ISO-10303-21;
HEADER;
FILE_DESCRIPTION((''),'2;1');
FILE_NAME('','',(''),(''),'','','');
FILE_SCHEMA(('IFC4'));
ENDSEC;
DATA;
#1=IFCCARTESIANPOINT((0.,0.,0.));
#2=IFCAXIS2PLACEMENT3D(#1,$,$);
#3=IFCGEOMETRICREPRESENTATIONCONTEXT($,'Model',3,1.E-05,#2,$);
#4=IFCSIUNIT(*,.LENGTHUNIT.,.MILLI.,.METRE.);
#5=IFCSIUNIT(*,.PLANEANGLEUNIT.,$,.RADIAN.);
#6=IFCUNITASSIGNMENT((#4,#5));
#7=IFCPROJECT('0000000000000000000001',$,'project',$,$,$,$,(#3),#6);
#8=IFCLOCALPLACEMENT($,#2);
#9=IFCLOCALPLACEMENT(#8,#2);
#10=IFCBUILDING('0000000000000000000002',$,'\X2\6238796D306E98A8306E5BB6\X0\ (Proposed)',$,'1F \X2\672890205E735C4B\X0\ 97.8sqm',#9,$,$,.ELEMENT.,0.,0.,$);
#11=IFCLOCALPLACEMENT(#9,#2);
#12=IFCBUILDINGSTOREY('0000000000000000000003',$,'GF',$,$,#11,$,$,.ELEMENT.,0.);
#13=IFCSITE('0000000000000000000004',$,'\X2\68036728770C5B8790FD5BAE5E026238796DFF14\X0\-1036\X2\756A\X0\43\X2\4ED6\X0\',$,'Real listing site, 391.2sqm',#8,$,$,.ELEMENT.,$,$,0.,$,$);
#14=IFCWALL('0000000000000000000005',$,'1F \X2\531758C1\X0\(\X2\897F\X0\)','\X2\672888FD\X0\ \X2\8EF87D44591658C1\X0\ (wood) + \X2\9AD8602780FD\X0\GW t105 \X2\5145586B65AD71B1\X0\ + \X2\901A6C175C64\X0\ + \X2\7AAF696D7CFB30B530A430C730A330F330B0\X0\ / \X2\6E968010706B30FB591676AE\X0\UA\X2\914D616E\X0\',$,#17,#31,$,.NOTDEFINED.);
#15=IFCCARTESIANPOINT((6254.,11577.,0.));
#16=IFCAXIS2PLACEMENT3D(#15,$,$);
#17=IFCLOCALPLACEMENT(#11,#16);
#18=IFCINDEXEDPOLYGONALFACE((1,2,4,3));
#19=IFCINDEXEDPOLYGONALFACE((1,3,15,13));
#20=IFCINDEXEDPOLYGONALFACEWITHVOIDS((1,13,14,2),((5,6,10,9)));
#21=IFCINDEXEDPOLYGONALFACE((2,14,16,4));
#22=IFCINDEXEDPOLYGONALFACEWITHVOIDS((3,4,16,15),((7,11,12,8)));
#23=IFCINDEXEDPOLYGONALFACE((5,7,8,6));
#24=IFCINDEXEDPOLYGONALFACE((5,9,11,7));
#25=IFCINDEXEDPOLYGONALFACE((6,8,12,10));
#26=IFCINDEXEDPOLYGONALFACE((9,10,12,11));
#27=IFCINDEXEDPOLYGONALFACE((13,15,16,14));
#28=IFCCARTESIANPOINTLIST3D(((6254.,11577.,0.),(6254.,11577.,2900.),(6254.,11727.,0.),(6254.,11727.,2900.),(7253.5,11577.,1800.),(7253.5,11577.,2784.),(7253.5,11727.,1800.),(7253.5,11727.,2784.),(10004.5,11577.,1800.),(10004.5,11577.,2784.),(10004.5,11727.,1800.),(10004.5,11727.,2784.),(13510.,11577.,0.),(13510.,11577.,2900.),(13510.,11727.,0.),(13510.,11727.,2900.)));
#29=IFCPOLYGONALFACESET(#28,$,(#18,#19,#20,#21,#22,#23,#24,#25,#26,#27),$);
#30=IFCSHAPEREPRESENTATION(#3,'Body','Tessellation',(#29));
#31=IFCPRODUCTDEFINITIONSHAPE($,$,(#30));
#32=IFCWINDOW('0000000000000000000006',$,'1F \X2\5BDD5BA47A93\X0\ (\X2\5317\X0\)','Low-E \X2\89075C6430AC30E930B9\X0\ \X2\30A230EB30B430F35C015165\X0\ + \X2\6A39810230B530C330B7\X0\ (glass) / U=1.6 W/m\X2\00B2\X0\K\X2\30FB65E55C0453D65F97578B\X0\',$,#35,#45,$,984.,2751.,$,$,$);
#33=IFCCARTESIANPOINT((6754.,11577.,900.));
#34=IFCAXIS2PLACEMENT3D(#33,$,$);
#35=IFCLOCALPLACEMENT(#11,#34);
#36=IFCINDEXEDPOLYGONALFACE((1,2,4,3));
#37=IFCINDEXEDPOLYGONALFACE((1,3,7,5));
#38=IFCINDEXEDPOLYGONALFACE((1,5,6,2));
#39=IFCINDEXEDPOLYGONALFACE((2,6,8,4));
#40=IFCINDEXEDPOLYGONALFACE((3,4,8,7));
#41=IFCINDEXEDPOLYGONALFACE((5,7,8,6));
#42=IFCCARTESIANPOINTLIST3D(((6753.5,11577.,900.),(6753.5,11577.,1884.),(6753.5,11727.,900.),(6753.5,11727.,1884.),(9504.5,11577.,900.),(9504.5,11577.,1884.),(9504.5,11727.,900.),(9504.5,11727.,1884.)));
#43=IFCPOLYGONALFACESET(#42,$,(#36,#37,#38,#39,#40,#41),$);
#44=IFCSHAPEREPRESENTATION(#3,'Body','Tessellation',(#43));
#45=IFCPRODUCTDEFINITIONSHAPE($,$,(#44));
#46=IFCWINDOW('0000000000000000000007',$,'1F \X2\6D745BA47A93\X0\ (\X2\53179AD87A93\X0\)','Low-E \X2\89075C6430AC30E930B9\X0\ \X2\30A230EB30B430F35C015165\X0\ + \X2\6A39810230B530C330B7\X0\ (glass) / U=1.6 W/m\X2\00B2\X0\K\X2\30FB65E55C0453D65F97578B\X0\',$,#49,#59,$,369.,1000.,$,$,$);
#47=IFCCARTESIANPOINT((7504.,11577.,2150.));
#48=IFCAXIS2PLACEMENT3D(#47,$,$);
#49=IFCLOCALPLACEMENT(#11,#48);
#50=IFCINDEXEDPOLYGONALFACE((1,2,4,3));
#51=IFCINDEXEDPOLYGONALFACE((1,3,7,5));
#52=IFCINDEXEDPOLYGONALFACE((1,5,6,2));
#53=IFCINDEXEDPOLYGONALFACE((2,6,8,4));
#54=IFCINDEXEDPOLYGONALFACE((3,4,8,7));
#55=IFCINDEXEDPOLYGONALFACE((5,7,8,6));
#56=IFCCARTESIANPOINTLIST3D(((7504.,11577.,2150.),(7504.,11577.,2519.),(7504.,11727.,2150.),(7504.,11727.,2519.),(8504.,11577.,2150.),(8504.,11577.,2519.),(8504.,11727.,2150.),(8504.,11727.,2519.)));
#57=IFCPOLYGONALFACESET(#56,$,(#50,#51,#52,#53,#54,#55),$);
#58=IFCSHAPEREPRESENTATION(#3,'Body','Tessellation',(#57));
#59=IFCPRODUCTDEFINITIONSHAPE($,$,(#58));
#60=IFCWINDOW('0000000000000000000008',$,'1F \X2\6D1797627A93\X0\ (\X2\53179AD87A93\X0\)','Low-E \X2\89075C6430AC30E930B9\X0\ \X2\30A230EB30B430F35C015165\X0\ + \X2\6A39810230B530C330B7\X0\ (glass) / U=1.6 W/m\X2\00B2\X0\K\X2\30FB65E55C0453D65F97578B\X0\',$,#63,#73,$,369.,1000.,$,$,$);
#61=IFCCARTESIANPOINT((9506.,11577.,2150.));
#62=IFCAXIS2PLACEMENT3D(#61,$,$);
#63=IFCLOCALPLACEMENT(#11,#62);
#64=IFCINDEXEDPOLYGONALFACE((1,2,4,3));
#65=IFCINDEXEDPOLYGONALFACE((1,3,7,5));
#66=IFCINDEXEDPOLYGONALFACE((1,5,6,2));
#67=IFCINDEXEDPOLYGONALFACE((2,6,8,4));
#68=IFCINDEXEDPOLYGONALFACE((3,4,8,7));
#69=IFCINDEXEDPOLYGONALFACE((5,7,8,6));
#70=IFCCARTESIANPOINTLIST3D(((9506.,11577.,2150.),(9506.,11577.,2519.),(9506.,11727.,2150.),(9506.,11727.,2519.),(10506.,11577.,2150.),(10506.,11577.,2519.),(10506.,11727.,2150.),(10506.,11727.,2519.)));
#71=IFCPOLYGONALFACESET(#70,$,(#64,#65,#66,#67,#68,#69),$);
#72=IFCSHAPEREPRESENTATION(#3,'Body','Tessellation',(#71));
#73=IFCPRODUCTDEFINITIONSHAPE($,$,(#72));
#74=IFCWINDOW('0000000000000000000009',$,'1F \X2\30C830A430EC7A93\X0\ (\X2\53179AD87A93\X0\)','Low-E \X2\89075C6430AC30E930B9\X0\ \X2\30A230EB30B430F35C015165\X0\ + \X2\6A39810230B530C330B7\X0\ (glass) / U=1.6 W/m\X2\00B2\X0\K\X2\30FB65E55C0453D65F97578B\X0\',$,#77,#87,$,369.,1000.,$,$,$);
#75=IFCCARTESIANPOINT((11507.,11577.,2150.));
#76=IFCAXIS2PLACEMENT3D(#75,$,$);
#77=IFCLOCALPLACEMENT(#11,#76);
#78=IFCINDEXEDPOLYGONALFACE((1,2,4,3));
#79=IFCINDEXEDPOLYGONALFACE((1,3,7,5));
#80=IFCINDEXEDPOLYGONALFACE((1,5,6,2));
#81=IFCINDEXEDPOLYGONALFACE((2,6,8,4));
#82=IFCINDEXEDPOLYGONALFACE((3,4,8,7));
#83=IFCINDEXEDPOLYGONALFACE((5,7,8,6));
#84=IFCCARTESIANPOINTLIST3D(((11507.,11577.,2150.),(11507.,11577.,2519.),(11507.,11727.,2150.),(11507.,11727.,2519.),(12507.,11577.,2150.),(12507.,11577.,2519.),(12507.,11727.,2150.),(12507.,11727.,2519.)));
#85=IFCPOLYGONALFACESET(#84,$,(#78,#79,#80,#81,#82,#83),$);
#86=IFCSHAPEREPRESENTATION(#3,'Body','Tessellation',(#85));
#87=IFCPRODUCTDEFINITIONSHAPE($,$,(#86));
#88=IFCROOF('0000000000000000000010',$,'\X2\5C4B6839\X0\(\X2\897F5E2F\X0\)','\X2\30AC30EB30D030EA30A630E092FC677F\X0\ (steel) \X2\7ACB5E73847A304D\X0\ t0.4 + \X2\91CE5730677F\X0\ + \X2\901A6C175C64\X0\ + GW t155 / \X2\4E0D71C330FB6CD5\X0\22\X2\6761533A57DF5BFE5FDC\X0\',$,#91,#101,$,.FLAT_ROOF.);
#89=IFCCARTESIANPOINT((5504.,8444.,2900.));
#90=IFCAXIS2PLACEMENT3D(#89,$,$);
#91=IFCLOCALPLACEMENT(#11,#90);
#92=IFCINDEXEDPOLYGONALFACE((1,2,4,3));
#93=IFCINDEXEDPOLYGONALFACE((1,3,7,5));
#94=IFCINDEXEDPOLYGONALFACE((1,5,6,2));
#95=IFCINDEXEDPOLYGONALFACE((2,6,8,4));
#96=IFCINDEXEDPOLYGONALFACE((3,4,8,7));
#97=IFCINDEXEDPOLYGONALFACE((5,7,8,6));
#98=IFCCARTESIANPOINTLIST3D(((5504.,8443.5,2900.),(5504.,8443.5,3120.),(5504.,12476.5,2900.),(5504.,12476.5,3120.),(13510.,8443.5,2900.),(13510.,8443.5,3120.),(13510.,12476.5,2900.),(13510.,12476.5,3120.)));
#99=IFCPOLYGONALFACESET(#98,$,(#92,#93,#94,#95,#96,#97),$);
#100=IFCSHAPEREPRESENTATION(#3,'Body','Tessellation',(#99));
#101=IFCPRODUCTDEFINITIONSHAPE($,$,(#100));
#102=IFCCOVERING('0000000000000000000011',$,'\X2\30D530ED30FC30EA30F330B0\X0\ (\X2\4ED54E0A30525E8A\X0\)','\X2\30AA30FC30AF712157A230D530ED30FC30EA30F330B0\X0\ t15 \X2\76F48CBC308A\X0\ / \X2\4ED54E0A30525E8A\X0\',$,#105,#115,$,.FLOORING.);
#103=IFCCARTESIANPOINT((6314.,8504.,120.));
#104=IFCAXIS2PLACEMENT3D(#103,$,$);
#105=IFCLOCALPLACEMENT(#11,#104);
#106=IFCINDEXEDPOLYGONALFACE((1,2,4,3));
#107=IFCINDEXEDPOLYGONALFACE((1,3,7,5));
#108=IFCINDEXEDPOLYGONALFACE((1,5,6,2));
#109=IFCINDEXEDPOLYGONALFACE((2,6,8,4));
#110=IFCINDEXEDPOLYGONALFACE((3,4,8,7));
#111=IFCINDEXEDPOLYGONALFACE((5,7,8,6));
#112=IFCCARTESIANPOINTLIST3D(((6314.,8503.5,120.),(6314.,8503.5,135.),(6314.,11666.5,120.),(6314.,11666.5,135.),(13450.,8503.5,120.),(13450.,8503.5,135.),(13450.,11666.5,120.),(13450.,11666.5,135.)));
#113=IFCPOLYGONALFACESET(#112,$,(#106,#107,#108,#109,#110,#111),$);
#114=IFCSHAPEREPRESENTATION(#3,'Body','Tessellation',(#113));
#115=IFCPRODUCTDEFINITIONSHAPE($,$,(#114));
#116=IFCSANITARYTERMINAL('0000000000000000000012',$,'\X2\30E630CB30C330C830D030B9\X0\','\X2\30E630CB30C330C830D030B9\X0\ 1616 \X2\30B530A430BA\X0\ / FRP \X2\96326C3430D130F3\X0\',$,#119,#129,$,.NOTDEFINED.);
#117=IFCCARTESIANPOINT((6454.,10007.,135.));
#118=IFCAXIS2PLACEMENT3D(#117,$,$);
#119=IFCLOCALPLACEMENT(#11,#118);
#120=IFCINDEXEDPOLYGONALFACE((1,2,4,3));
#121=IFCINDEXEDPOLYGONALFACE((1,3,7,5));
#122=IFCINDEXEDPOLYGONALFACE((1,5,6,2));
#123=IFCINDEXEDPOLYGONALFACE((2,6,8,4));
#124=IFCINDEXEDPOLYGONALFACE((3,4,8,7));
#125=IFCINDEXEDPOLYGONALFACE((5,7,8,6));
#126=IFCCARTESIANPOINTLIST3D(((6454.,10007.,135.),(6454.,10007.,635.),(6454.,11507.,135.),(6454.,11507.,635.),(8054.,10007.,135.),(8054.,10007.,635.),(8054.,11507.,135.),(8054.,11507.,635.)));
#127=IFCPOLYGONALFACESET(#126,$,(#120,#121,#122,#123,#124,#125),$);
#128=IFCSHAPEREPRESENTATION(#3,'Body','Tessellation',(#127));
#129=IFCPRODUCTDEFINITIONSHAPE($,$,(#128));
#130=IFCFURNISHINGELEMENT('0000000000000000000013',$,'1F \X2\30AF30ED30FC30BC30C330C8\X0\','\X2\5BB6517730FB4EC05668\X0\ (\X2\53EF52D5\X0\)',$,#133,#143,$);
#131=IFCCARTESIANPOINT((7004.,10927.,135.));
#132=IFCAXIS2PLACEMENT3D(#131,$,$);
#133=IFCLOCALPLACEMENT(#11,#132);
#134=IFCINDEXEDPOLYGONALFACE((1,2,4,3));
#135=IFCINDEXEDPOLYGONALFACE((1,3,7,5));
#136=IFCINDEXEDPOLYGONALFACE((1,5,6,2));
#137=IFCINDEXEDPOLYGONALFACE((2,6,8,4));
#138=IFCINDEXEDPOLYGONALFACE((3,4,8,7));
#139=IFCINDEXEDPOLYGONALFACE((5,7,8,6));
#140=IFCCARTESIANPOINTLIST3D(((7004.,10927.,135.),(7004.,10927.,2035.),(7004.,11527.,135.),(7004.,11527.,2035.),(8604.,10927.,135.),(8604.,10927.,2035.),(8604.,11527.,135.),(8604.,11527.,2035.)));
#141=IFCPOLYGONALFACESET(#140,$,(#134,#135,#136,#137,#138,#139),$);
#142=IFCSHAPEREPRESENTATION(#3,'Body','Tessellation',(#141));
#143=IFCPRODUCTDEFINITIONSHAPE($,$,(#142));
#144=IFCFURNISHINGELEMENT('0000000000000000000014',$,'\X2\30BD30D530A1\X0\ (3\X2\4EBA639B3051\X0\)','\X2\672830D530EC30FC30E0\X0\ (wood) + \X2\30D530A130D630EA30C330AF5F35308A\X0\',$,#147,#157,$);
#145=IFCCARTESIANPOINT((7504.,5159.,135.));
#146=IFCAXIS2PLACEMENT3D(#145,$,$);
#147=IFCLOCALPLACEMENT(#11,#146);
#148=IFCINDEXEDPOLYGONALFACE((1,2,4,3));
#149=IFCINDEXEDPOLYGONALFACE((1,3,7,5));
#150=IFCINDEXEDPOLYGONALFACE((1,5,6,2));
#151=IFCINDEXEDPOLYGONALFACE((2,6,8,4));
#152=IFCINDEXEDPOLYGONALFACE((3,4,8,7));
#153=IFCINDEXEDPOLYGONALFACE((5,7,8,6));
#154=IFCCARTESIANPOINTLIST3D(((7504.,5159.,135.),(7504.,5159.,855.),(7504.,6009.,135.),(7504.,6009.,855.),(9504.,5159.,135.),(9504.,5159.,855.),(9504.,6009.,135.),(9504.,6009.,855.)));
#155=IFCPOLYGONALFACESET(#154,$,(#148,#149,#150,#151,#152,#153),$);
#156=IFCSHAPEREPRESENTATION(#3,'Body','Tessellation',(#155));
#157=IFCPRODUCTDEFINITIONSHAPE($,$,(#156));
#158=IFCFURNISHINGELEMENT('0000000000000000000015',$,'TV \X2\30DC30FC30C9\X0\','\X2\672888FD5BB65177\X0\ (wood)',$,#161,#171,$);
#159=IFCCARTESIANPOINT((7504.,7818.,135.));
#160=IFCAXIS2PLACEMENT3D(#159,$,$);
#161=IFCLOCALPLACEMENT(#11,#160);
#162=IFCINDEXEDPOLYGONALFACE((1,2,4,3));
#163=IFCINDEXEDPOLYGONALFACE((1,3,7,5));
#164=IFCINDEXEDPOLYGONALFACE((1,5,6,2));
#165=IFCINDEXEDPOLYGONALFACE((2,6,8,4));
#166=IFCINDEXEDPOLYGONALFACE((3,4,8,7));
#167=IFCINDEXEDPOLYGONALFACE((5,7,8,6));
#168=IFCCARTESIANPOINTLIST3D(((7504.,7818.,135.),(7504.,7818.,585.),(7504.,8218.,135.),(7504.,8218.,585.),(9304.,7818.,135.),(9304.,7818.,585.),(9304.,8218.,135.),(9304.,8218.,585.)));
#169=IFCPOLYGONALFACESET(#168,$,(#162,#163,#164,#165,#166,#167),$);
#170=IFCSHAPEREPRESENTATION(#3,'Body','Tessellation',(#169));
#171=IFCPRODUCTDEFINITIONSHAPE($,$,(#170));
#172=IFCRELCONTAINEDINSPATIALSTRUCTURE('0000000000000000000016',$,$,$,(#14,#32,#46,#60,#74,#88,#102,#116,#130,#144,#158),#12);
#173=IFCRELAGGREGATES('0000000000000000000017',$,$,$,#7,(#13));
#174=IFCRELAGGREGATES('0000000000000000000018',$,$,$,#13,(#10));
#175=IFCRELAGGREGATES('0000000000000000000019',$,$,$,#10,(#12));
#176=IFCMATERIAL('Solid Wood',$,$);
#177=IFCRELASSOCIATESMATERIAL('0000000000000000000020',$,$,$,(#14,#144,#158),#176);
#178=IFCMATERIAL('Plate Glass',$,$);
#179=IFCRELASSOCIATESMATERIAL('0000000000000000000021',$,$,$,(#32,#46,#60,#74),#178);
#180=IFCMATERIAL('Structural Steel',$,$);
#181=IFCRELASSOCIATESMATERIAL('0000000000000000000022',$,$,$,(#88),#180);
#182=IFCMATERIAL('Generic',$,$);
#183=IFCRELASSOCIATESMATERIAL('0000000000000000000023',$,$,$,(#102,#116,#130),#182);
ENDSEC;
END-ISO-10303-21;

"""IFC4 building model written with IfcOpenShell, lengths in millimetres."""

from ifc_helpers import new_model, si_unit, frame, frame_2d, origin, place, context, project, spatial, rectangle, extrude, material, element, fill, save


model = new_model("IFC4")

# Units and contexts
model_context = context("Model", 3, precision=1e-05, world=origin())
ifc_project = project(units=[si_unit("LENGTHUNIT", "METRE", prefix="MILLI"), si_unit("PLANEANGLEUNIT", "RADIAN")], contexts=[model_context])

# Site, building, storey
site_placement = place(None, origin())
site = spatial("IfcSite", under=ifc_project, at=site_placement, Name="栃木県宇都宮市戸祭４-1036番43他", ObjectType="Real listing site, 391.2sqm", CompositionType="ELEMENT", RefElevation=0.0)
building_placement = place(site_placement, origin())
building = spatial("IfcBuilding", under=site, at=building_placement, Name="戸祭の風の家 (Proposed)", ObjectType="1F 木造平屋 97.8sqm", CompositionType="ELEMENT", ElevationOfRefHeight=0.0, ElevationOfTerrain=0.0)
storey_placement = place(building_placement, origin())
storey = spatial("IfcBuildingStorey", under=building, at=storey_placement, Name="GF", CompositionType="ELEMENT", Elevation=0.0)

# Shared definitions
ifc_material_1 = material(Name="Solid Wood")

# Shared definitions
ifc_material_2 = material(Name="Plate Glass")

# Wall, openings, windows
wall_1_placement = place(storey_placement, frame((6254.0, 11577.0, 0.0)))
wall_1 = element("IfcWall", 1, at=wall_1_placement, inside=storey, material=ifc_material_1, Name="1F 北壁(西)", Description="木製 軸組外壁 (wood) + 高性能GW t105 充填断熱 + 通気層 + 窯業系サイディング / 準耐火・外皮UA配慮", PredefinedType="NOTDEFINED", context=model_context, shape_type="SweptSolid", body=[
    extrude(rectangle(XDim=7256.0, YDim=150.0, at=frame_2d((3628.0, 75.0))), frame((6254.0, 11577.0, 0.0)), (0.0, 0.0, 1.0), 2900.0),
])
opening_1_placement = place(storey_placement, frame((6754.0, 11577.0, 900.0)))
opening_1 = element("IfcOpeningElement", 2, at=opening_1_placement, cuts=wall_1, PredefinedType="NOTDEFINED", context=model_context, shape_type="SweptSolid", body=[
    extrude(rectangle(XDim=2751.0, YDim=150.0, at=frame_2d((1375.0, 75.0))), frame((6754.0, 11577.0, 900.0)), (0.0, 0.0, 1.0), 984.0),
])
opening_2_placement = place(storey_placement, frame((7504.0, 11577.0, 2150.0)))
opening_2 = element("IfcOpeningElement", 3, at=opening_2_placement, cuts=wall_1, PredefinedType="NOTDEFINED", context=model_context, shape_type="SweptSolid", body=[
    extrude(rectangle(XDim=1000.0, YDim=150.0, at=frame_2d((500.0, 75.0))), frame((7504.0, 11577.0, 2150.0)), (0.0, 0.0, 1.0), 369.0),
])
opening_3_placement = place(storey_placement, frame((9506.0, 11577.0, 2150.0)))
opening_3 = element("IfcOpeningElement", 4, at=opening_3_placement, cuts=wall_1, PredefinedType="NOTDEFINED", context=model_context, shape_type="SweptSolid", body=[
    extrude(rectangle(XDim=1000.0, YDim=150.0, at=frame_2d((500.0, 75.0))), frame((9506.0, 11577.0, 2150.0)), (0.0, 0.0, 1.0), 369.0),
])
opening_4_placement = place(storey_placement, frame((11507.0, 11577.0, 2150.0)))
opening_4 = element("IfcOpeningElement", 5, at=opening_4_placement, cuts=wall_1, PredefinedType="NOTDEFINED", context=model_context, shape_type="SweptSolid", body=[
    extrude(rectangle(XDim=1000.0, YDim=150.0, at=frame_2d((500.0, 75.0))), frame((11507.0, 11577.0, 2150.0)), (0.0, 0.0, 1.0), 369.0),
])
window_1_placement = place(storey_placement, frame((6754.0, 11577.0, 900.0)))
window_1 = element("IfcWindow", 6, at=window_1_placement, inside=storey, material=ifc_material_2, Name="1F 寝室窓 (北)", Description="Low-E 複層ガラス アルゴン封入 + 樹脂サッシ (glass) / U=1.6 W/m²K・日射取得型", OverallHeight=984.0, OverallWidth=2751.0, context=model_context, shape_type="SweptSolid", body=[
    extrude(rectangle(XDim=2751.0, YDim=150.0, at=frame_2d((1375.0, 75.0))), frame((6754.0, 11577.0, 900.0)), (0.0, 0.0, 1.0), 984.0),
])
fill(opening_1, window_1)
window_2_placement = place(storey_placement, frame((7504.0, 11577.0, 2150.0)))
window_2 = element("IfcWindow", 7, at=window_2_placement, inside=storey, material=ifc_material_2, Name="1F 浴室窓 (北高窓)", Description="Low-E 複層ガラス アルゴン封入 + 樹脂サッシ (glass) / U=1.6 W/m²K・日射取得型", OverallHeight=369.0, OverallWidth=1000.0, context=model_context, shape_type="SweptSolid", body=[
    extrude(rectangle(XDim=1000.0, YDim=150.0, at=frame_2d((500.0, 75.0))), frame((7504.0, 11577.0, 2150.0)), (0.0, 0.0, 1.0), 369.0),
])
fill(opening_2, window_2)
window_3_placement = place(storey_placement, frame((9506.0, 11577.0, 2150.0)))
window_3 = element("IfcWindow", 8, at=window_3_placement, inside=storey, material=ifc_material_2, Name="1F 洗面窓 (北高窓)", Description="Low-E 複層ガラス アルゴン封入 + 樹脂サッシ (glass) / U=1.6 W/m²K・日射取得型", OverallHeight=369.0, OverallWidth=1000.0, context=model_context, shape_type="SweptSolid", body=[
    extrude(rectangle(XDim=1000.0, YDim=150.0, at=frame_2d((500.0, 75.0))), frame((9506.0, 11577.0, 2150.0)), (0.0, 0.0, 1.0), 369.0),
])
fill(opening_3, window_3)
window_4_placement = place(storey_placement, frame((11507.0, 11577.0, 2150.0)))
window_4 = element("IfcWindow", 9, at=window_4_placement, inside=storey, material=ifc_material_2, Name="1F トイレ窓 (北高窓)", Description="Low-E 複層ガラス アルゴン封入 + 樹脂サッシ (glass) / U=1.6 W/m²K・日射取得型", OverallHeight=369.0, OverallWidth=1000.0, context=model_context, shape_type="SweptSolid", body=[
    extrude(rectangle(XDim=1000.0, YDim=150.0, at=frame_2d((500.0, 75.0))), frame((11507.0, 11577.0, 2150.0)), (0.0, 0.0, 1.0), 369.0),
])
fill(opening_4, window_4)

# Roof
ifc_material_3 = material(Name="Structural Steel")
roof_1_placement = place(storey_placement, frame((5504.0, 8444.0, 2900.0)))
element("IfcRoof", 10, at=roof_1_placement, inside=storey, material=ifc_material_3, Name="屋根(西帯)", Description="ガルバリウム鋼板 (steel) 立平葺き t0.4 + 野地板 + 通気層 + GW t155 / 不燃・法22条区域対応", PredefinedType="FLAT_ROOF", context=model_context, shape_type="SweptSolid", body=[
    extrude(rectangle(XDim=8006.0, YDim=4033.0, at=frame_2d((4003.0, 2016.0))), frame((5504.0, 8444.0, 2900.0)), (0.0, 0.0, 1.0), 220.0),
])

# Covering
ifc_material_4 = material(Name="Generic")
covering_1_placement = place(storey_placement, frame((6314.0, 8504.0, 120.0)))
element("IfcCovering", 11, at=covering_1_placement, inside=storey, material=ifc_material_4, Name="フローリング (仕上げ床)", Description="オーク無垢フローリング t15 直貼り / 仕上げ床", PredefinedType="FLOORING", context=model_context, shape_type="SweptSolid", body=[
    extrude(rectangle(XDim=7136.0, YDim=3163.0, at=frame_2d((3568.0, 1581.0))), frame((6314.0, 8504.0, 120.0)), (0.0, 0.0, 1.0), 15.0),
])

# Sanitary terminal
sanitary_terminal_placement = place(storey_placement, frame((6454.0, 10007.0, 135.0)))
element("IfcSanitaryTerminal", 12, at=sanitary_terminal_placement, inside=storey, material=ifc_material_4, Name="ユニットバス", Description="ユニットバス 1616 サイズ / FRP 防水パン", PredefinedType="NOTDEFINED", context=model_context, shape_type="SweptSolid", body=[
    extrude(rectangle(XDim=1600.0, YDim=1500.0, at=frame_2d((800.0, 750.0))), frame((6454.0, 10007.0, 135.0)), (0.0, 0.0, 1.0), 500.0),
])

# Furnishing elements
furnishing_1_placement = place(storey_placement, frame((7004.0, 10927.0, 135.0)))
element("IfcFurnishingElement", 13, at=furnishing_1_placement, inside=storey, material=ifc_material_4, Name="1F クローゼット", Description="家具・什器 (可動)", context=model_context, shape_type="SweptSolid", body=[
    extrude(rectangle(XDim=1600.0, YDim=600.0, at=frame_2d((800.0, 300.0))), frame((7004.0, 10927.0, 135.0)), (0.0, 0.0, 1.0), 1900.0),
])
furnishing_2_placement = place(storey_placement, frame((7504.0, 5159.0, 135.0)))
element("IfcFurnishingElement", 14, at=furnishing_2_placement, inside=storey, material=ifc_material_1, Name="ソファ (3人掛け)", Description="木フレーム (wood) + ファブリック張り", context=model_context, shape_type="SweptSolid", body=[
    extrude(rectangle(XDim=2000.0, YDim=850.0, at=frame_2d((1000.0, 425.0))), frame((7504.0, 5159.0, 135.0)), (0.0, 0.0, 1.0), 720.0),
])
furnishing_3_placement = place(storey_placement, frame((7504.0, 7818.0, 135.0)))
element("IfcFurnishingElement", 15, at=furnishing_3_placement, inside=storey, material=ifc_material_1, Name="TV ボード", Description="木製家具 (wood)", context=model_context, shape_type="SweptSolid", body=[
    extrude(rectangle(XDim=1800.0, YDim=400.0, at=frame_2d((900.0, 200.0))), frame((7504.0, 7818.0, 135.0)), (0.0, 0.0, 1.0), 450.0),
])

save(model, "model.ifc")
